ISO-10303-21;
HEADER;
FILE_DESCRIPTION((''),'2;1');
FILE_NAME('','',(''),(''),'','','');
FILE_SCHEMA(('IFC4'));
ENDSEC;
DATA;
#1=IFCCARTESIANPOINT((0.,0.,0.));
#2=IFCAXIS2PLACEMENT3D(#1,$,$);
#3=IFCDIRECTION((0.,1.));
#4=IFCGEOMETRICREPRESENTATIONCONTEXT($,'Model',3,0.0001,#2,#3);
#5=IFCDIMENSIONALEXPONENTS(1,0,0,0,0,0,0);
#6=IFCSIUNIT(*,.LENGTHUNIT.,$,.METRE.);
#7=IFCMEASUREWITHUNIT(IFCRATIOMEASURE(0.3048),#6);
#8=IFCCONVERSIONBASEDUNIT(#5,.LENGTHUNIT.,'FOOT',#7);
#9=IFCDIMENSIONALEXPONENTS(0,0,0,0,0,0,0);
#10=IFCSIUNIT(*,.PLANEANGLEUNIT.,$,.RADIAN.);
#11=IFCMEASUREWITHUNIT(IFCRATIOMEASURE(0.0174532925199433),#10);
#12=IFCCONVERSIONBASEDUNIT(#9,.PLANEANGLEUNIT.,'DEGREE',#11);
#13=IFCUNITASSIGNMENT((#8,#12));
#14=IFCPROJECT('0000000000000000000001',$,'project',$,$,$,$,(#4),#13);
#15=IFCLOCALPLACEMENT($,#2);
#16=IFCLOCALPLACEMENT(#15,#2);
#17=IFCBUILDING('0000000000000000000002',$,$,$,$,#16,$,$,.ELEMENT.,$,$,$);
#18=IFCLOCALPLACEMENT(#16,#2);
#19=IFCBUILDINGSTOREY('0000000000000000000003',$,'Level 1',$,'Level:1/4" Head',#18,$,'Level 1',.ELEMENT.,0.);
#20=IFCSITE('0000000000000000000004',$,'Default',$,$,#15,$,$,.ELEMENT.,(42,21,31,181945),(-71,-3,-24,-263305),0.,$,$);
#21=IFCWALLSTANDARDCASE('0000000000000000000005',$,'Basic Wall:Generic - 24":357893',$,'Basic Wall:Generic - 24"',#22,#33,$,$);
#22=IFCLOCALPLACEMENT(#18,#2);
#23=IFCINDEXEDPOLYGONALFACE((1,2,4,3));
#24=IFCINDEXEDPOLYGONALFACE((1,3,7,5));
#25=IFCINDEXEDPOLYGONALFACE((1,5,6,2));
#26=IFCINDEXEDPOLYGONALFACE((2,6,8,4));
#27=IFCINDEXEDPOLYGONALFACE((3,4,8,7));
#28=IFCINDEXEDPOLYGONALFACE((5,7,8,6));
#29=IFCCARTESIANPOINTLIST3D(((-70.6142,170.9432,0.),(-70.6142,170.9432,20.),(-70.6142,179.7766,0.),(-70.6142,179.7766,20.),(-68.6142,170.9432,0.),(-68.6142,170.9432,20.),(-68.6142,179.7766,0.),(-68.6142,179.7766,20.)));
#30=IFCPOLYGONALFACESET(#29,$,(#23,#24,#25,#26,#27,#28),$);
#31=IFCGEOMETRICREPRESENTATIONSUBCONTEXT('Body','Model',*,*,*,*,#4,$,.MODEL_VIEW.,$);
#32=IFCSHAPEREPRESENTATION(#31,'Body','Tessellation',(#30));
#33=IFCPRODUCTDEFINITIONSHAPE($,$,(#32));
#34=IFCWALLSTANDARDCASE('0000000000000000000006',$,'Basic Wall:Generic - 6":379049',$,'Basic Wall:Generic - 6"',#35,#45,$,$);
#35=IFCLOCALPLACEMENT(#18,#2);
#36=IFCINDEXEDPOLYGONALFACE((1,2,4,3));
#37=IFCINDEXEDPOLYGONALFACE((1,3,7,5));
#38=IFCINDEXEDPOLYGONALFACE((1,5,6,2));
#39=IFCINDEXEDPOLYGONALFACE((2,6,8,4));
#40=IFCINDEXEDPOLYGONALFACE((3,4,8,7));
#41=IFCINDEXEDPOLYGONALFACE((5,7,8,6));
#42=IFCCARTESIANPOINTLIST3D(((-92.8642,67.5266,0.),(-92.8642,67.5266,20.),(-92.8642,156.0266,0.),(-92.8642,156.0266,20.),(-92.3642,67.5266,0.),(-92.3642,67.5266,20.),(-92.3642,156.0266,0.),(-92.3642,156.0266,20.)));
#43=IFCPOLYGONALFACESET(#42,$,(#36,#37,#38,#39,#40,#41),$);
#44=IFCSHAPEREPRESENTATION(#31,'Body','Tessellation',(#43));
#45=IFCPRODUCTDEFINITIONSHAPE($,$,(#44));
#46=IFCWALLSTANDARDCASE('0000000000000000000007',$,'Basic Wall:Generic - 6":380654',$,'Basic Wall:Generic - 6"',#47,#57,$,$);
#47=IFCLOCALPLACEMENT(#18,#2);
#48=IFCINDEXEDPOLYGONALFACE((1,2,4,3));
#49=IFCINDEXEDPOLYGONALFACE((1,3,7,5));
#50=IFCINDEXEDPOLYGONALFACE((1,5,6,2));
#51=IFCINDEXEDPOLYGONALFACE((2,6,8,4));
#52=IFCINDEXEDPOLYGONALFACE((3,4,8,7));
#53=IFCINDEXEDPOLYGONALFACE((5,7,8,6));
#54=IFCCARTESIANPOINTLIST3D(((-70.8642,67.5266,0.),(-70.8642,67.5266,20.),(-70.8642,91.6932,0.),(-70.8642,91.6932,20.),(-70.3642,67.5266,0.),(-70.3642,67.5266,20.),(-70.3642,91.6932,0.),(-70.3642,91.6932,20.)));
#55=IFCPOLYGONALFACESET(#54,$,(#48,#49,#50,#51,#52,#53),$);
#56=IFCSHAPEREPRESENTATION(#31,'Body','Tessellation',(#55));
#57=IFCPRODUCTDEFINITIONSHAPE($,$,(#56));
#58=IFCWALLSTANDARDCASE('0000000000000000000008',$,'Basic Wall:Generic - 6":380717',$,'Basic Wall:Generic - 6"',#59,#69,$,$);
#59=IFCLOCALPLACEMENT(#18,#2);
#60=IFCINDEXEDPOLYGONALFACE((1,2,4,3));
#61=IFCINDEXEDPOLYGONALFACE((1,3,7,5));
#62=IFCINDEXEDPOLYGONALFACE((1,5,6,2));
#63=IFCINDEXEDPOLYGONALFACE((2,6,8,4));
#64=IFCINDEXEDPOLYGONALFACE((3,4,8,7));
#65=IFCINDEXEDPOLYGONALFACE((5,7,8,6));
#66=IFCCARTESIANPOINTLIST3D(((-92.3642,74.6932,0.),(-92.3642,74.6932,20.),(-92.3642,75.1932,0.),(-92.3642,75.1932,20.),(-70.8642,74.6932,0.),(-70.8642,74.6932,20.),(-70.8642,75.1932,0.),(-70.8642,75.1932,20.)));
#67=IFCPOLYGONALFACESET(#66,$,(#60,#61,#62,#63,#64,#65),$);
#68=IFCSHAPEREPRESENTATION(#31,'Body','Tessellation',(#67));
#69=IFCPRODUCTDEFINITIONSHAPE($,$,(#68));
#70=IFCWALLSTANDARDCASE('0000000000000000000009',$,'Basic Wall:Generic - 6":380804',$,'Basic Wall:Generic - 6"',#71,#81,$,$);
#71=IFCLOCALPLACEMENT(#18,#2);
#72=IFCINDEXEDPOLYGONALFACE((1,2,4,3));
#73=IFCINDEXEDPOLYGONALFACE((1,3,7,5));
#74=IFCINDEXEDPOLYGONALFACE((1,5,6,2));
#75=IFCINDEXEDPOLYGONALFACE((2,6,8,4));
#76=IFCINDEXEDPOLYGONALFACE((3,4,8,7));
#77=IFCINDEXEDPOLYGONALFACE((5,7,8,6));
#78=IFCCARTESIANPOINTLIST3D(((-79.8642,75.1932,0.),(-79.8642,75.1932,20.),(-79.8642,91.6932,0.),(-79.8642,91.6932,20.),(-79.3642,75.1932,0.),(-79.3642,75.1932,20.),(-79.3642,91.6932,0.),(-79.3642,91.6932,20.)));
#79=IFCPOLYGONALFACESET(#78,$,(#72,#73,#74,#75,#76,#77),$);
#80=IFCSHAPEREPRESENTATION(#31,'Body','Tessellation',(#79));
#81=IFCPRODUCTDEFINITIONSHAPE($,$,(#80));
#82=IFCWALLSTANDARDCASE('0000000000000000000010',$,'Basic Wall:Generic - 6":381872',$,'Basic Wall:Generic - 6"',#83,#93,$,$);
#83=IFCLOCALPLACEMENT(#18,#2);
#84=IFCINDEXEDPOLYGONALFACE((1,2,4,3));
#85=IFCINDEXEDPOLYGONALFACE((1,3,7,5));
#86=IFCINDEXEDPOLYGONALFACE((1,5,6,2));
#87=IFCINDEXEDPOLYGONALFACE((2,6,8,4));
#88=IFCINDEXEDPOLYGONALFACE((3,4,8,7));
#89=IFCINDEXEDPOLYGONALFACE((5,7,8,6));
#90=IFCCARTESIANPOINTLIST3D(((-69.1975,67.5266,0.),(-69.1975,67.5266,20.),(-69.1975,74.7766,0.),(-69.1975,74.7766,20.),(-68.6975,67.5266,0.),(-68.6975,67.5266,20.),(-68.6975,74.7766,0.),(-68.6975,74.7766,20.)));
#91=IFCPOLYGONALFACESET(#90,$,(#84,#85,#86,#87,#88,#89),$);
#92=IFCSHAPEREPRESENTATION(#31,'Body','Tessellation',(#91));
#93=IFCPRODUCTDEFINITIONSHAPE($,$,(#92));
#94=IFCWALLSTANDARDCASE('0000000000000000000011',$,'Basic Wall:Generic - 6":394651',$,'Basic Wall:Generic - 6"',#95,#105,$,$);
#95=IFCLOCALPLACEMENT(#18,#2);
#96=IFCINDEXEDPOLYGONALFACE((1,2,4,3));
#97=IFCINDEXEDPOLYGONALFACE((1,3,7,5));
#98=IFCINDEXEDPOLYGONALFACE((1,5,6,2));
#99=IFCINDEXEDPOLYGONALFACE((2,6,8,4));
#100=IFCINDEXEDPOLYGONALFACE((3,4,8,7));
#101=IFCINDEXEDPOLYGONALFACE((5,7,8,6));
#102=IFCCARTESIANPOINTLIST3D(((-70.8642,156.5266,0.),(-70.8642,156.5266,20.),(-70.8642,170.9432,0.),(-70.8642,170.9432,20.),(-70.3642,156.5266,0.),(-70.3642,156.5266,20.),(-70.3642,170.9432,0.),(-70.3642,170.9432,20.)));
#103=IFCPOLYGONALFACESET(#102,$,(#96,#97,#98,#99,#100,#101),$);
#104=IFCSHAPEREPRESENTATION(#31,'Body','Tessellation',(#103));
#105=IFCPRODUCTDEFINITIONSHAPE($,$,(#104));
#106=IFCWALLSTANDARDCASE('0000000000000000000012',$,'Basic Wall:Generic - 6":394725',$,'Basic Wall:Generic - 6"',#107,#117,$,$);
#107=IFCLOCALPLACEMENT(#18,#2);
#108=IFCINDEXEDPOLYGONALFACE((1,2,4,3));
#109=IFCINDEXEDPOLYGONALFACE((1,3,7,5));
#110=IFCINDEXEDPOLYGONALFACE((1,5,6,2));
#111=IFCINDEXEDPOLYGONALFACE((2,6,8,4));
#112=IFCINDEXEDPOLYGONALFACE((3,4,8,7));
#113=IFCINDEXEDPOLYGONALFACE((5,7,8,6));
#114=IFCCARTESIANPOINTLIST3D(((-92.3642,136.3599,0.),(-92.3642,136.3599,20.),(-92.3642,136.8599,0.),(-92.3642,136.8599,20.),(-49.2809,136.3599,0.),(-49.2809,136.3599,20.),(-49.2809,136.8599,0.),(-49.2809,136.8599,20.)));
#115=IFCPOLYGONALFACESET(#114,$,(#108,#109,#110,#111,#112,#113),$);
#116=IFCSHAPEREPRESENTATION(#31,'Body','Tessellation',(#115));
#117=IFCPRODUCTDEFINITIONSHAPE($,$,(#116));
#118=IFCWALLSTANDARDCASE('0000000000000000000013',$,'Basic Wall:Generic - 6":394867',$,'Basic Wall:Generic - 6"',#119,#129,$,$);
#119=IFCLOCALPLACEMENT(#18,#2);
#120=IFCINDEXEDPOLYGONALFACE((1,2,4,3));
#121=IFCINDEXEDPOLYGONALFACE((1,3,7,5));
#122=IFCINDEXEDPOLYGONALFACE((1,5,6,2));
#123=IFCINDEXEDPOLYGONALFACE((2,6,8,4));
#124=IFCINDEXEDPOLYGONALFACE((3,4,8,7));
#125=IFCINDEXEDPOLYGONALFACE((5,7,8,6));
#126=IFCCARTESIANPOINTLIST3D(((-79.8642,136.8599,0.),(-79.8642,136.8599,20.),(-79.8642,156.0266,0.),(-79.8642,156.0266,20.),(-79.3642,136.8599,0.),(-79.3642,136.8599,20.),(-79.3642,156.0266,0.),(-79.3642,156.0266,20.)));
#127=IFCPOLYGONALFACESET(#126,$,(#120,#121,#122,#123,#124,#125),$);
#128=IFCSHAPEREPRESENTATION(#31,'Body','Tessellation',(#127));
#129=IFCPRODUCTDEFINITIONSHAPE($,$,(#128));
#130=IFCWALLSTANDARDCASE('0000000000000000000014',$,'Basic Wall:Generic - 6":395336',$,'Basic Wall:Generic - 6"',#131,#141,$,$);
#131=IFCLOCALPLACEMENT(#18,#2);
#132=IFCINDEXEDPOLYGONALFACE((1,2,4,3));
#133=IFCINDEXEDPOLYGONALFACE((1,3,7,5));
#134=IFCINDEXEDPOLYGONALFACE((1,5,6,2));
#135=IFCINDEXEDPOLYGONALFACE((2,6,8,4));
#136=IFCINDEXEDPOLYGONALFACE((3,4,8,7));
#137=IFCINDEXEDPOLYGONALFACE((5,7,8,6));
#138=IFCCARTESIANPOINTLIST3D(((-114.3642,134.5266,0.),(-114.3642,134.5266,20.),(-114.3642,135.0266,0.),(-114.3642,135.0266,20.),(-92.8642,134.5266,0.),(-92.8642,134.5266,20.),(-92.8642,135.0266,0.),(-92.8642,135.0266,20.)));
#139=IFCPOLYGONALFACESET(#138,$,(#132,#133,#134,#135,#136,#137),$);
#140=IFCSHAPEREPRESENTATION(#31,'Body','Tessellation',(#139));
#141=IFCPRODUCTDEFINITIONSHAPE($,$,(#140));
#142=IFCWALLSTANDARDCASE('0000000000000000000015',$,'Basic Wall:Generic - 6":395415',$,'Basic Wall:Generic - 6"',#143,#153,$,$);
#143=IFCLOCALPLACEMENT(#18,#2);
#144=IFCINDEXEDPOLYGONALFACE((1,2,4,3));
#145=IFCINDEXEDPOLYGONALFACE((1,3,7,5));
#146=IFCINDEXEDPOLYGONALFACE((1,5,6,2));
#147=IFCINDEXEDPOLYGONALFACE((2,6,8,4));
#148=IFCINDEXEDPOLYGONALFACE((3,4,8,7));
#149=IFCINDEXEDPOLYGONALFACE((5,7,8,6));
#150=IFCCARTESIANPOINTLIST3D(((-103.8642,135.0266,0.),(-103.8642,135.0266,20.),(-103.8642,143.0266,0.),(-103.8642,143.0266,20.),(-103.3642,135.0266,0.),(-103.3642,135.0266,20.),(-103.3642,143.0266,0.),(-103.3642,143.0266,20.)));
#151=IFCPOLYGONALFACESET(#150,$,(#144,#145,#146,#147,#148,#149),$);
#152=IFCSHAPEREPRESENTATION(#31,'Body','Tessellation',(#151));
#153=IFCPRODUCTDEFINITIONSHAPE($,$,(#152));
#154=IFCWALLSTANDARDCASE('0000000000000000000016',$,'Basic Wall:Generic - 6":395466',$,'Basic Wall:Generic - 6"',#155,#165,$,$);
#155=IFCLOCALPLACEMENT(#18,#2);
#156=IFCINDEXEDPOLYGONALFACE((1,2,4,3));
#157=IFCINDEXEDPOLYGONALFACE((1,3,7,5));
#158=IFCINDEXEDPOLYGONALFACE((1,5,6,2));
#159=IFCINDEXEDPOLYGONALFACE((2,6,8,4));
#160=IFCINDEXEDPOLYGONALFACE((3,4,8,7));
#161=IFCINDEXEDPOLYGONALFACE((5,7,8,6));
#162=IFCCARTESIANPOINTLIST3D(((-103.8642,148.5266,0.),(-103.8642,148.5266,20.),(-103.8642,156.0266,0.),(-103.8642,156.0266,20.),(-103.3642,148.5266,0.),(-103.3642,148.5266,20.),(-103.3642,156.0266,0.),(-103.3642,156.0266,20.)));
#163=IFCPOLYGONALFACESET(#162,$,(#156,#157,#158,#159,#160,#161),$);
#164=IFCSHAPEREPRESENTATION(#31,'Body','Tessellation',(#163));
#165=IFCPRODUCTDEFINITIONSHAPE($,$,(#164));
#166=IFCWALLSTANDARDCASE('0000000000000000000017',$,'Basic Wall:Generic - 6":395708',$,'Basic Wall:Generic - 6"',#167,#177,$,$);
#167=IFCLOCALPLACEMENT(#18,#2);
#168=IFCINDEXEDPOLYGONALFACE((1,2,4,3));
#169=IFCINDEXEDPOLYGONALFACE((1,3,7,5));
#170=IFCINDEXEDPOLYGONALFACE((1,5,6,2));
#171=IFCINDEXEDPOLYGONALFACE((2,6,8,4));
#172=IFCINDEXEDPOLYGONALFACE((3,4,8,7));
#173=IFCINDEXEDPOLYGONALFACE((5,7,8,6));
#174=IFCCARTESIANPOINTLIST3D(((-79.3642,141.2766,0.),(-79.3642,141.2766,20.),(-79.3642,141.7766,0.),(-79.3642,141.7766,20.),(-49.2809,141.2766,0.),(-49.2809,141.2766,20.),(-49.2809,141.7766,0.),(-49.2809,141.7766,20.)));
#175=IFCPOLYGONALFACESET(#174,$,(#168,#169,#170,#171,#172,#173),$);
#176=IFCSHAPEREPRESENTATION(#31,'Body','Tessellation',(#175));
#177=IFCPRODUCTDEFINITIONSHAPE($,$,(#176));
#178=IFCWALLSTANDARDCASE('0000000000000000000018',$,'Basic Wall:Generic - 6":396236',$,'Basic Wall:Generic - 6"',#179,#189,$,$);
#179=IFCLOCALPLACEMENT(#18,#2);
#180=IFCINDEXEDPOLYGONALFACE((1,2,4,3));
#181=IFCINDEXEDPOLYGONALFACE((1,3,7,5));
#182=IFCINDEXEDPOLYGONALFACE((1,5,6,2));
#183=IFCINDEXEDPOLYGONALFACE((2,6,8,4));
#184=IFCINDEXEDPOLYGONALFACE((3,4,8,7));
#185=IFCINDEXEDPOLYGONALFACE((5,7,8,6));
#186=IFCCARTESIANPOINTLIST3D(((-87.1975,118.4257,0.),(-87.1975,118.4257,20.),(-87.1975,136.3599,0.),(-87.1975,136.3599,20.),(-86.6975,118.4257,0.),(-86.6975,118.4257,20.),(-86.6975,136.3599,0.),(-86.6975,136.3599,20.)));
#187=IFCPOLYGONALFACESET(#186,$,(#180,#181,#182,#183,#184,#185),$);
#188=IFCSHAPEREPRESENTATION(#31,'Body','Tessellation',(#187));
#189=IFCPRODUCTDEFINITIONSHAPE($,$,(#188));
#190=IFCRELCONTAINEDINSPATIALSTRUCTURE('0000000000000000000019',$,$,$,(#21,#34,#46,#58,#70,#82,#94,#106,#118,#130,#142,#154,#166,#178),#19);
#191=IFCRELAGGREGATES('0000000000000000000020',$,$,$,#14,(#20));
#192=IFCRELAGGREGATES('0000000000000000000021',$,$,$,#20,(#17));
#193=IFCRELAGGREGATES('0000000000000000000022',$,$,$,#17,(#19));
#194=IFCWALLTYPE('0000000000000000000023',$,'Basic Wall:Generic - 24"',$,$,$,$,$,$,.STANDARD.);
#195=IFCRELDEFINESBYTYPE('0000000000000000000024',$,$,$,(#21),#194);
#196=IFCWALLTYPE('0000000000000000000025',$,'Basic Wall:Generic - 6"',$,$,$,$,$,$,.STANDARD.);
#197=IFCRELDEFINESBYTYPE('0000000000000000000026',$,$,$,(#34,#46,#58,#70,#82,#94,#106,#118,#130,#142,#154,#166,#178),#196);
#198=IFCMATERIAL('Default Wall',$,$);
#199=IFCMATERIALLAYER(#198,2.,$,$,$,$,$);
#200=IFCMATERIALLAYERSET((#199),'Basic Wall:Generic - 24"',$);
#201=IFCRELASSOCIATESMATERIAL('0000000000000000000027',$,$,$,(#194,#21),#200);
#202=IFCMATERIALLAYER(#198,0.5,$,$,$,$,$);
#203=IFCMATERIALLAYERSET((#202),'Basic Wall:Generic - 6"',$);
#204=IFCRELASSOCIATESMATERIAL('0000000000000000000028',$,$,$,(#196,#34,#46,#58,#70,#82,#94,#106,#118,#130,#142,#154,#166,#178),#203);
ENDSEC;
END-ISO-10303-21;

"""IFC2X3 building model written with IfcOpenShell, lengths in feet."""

from ifc_helpers import new_model, entity, si_unit, converted_unit, direction, frame, frame_2d, origin, place, context, subcontext, project, spatial, rectangle, extrude, material, layer, layer_set, layer_usage, type_object, element, save


model = new_model("IFC2X3")

# Units and contexts
model_context = context("Model", 3, precision=0.0001, world=origin(), true_north=direction((0.0, 1.0)))
body_context = subcontext(model_context, "Body", "Model", "MODEL_VIEW")
ifc_project = project(units=[converted_unit("LENGTHUNIT", "FOOT", entity("IfcRatioMeasure", 0.3048), si_unit("LENGTHUNIT", "METRE"), dimensions=[1, 0, 0, 0, 0, 0, 0]), converted_unit("PLANEANGLEUNIT", "DEGREE", entity("IfcRatioMeasure", 0.0174532925199433), si_unit("PLANEANGLEUNIT", "RADIAN"), dimensions=[0, 0, 0, 0, 0, 0, 0])], contexts=[model_context])

# Site, building, storey
site_placement = place(None, origin())
site = spatial("IfcSite", under=ifc_project, at=site_placement, Name="Default", CompositionType="ELEMENT", RefLatitude=(42, 21, 31, 181945), RefLongitude=(-71, -3, -24, -263305), RefElevation=0.0)
building_placement = place(site_placement, origin())
building = spatial("IfcBuilding", under=site, at=building_placement, CompositionType="ELEMENT")
storey_placement = place(building_placement, origin())
storey = spatial("IfcBuildingStorey", under=building, at=storey_placement, Name="Level 1", ObjectType="Level:1/4\" Head", LongName="Level 1", CompositionType="ELEMENT", Elevation=0.0)

# Walls
ifc_material = material(Name="Default Wall")
ifc_layer_1 = layer(ifc_material, 2.0)
ifc_layer_set_1 = layer_set([ifc_layer_1], Name="Basic Wall:Generic - 24\"")
ifc_layer_usage_1 = layer_usage(ifc_layer_set_1, "AXIS2", "NEGATIVE", 1.0)
wall_type_1 = type_object("IfcWallType", Name="Basic Wall:Generic - 24\"", PredefinedType="STANDARD", material=ifc_layer_set_1)
wall_1_placement = place(storey_placement, frame((-69.6142, 179.7766, 0.0), z_axis=(0.0, 0.0, 1.0), x_axis=(0.0, -1.0, 0.0)))
element("IfcWallStandardCase", 1, at=wall_1_placement, inside=storey, type_object=wall_type_1, material=ifc_layer_usage_1, Name="Basic Wall:Generic - 24\":357893", ObjectType="Basic Wall:Generic - 24\"", context=body_context, shape_type="SweptSolid", body=[
    extrude(rectangle(XDim=8.8333, YDim=2.0, at=frame_2d((4.4167, 0.0), x_axis=(-1.0, 0.0))), origin(), (0.0, 0.0, 1.0), 20.0),
])
ifc_layer_2 = layer(ifc_material, 0.5)
ifc_layer_set_2 = layer_set([ifc_layer_2], Name="Basic Wall:Generic - 6\"")
ifc_layer_usage_2 = layer_usage(ifc_layer_set_2, "AXIS2", "NEGATIVE", 0.25)
wall_type_2 = type_object("IfcWallType", Name="Basic Wall:Generic - 6\"", PredefinedType="STANDARD", material=ifc_layer_set_2)
wall_2_placement = place(storey_placement, frame((-92.6142, 67.5266, 0.0), z_axis=(0.0, 0.0, 1.0), x_axis=(0.0, 1.0, 0.0)))
element("IfcWallStandardCase", 2, at=wall_2_placement, inside=storey, type_object=wall_type_2, material=ifc_layer_usage_2, Name="Basic Wall:Generic - 6\":379049", ObjectType="Basic Wall:Generic - 6\"", context=body_context, shape_type="SweptSolid", body=[
    extrude(rectangle(XDim=88.5, YDim=0.5, at=frame_2d((44.25, 0.0), x_axis=(-1.0, 0.0))), origin(), (0.0, 0.0, 1.0), 20.0),
])
ifc_layer_usage_3 = layer_usage(ifc_layer_set_2, "AXIS2", "NEGATIVE", 0.25)
wall_3_placement = place(storey_placement, frame((-70.6142, 67.5266, 0.0), z_axis=(0.0, 0.0, 1.0), x_axis=(0.0, 1.0, 0.0)))
element("IfcWallStandardCase", 3, at=wall_3_placement, inside=storey, type_object=wall_type_2, material=ifc_layer_usage_3, Name="Basic Wall:Generic - 6\":380654", ObjectType="Basic Wall:Generic - 6\"", context=body_context, shape_type="SweptSolid", body=[
    extrude(rectangle(XDim=24.1667, YDim=0.5, at=frame_2d((12.0833, 0.0), x_axis=(-1.0, 0.0))), origin(), (0.0, 0.0, 1.0), 20.0),
])
ifc_layer_usage_4 = layer_usage(ifc_layer_set_2, "AXIS2", "NEGATIVE", 0.25)
wall_4_placement = place(storey_placement, frame((-70.8642, 74.9432, 0.0), z_axis=(0.0, 0.0, 1.0), x_axis=(-1.0, 0.0, 0.0)))
element("IfcWallStandardCase", 4, at=wall_4_placement, inside=storey, type_object=wall_type_2, material=ifc_layer_usage_4, Name="Basic Wall:Generic - 6\":380717", ObjectType="Basic Wall:Generic - 6\"", context=body_context, shape_type="SweptSolid", body=[
    extrude(rectangle(XDim=21.5, YDim=0.5, at=frame_2d((10.75, 0.0), x_axis=(-1.0, 0.0))), origin(), (0.0, 0.0, 1.0), 20.0),
])
ifc_layer_usage_5 = layer_usage(ifc_layer_set_2, "AXIS2", "NEGATIVE", 0.25)
wall_5_placement = place(storey_placement, frame((-79.6142, 75.1932, 0.0), z_axis=(0.0, 0.0, 1.0), x_axis=(0.0, 1.0, 0.0)))
element("IfcWallStandardCase", 5, at=wall_5_placement, inside=storey, type_object=wall_type_2, material=ifc_layer_usage_5, Name="Basic Wall:Generic - 6\":380804", ObjectType="Basic Wall:Generic - 6\"", context=body_context, shape_type="SweptSolid", body=[
    extrude(rectangle(XDim=16.5, YDim=0.5, at=frame_2d((8.25, 0.0), x_axis=(-1.0, 0.0))), origin(), (0.0, 0.0, 1.0), 20.0),
])
ifc_layer_usage_6 = layer_usage(ifc_layer_set_2, "AXIS2", "NEGATIVE", 0.25)
wall_6_placement = place(storey_placement, frame((-68.9475, 74.7766, 0.0), z_axis=(0.0, 0.0, 1.0), x_axis=(0.0, -1.0, 0.0)))
element("IfcWallStandardCase", 6, at=wall_6_placement, inside=storey, type_object=wall_type_2, material=ifc_layer_usage_6, Name="Basic Wall:Generic - 6\":381872", ObjectType="Basic Wall:Generic - 6\"", context=body_context, shape_type="SweptSolid", body=[
    extrude(rectangle(XDim=7.25, YDim=0.5, at=frame_2d((3.625, 0.0), x_axis=(-1.0, 0.0))), origin(), (0.0, 0.0, 1.0), 20.0),
])
ifc_layer_usage_7 = layer_usage(ifc_layer_set_2, "AXIS2", "NEGATIVE", 0.25)
wall_7_placement = place(storey_placement, frame((-70.6142, 170.9432, 0.0), z_axis=(0.0, 0.0, 1.0), x_axis=(0.0, -1.0, 0.0)))
element("IfcWallStandardCase", 7, at=wall_7_placement, inside=storey, type_object=wall_type_2, material=ifc_layer_usage_7, Name="Basic Wall:Generic - 6\":394651", ObjectType="Basic Wall:Generic - 6\"", context=body_context, shape_type="SweptSolid", body=[
    extrude(rectangle(XDim=14.4167, YDim=0.5, at=frame_2d((7.2083, 0.0), x_axis=(-1.0, 0.0))), origin(), (0.0, 0.0, 1.0), 20.0),
])
ifc_layer_usage_8 = layer_usage(ifc_layer_set_2, "AXIS2", "NEGATIVE", 0.25)
wall_8_placement = place(storey_placement, frame((-92.3642, 136.6099, 0.0)))
element("IfcWallStandardCase", 8, at=wall_8_placement, inside=storey, type_object=wall_type_2, material=ifc_layer_usage_8, Name="Basic Wall:Generic - 6\":394725", ObjectType="Basic Wall:Generic - 6\"", context=body_context, shape_type="SweptSolid", body=[
    extrude(rectangle(XDim=43.0833, YDim=0.5, at=frame_2d((21.5417, 0.0), x_axis=(-1.0, 0.0))), origin(), (0.0, 0.0, 1.0), 20.0),
])
ifc_layer_usage_9 = layer_usage(ifc_layer_set_2, "AXIS2", "NEGATIVE", 0.25)
wall_9_placement = place(storey_placement, frame((-79.6142, 156.0266, 0.0), z_axis=(0.0, 0.0, 1.0), x_axis=(0.0, -1.0, 0.0)))
element("IfcWallStandardCase", 9, at=wall_9_placement, inside=storey, type_object=wall_type_2, material=ifc_layer_usage_9, Name="Basic Wall:Generic - 6\":394867", ObjectType="Basic Wall:Generic - 6\"", context=body_context, shape_type="SweptSolid", body=[
    extrude(rectangle(XDim=19.1667, YDim=0.5, at=frame_2d((9.5833, 0.0), x_axis=(-1.0, 0.0))), origin(), (0.0, 0.0, 1.0), 20.0),
])
ifc_layer_usage_10 = layer_usage(ifc_layer_set_2, "AXIS2", "POSITIVE", -0.25)
wall_10_placement = place(storey_placement, frame((-92.8642, 134.7766, 0.0), z_axis=(0.0, 0.0, 1.0), x_axis=(-1.0, 0.0, 0.0)))
element("IfcWallStandardCase", 10, at=wall_10_placement, inside=storey, type_object=wall_type_2, material=ifc_layer_usage_10, Name="Basic Wall:Generic - 6\":395336", ObjectType="Basic Wall:Generic - 6\"", context=body_context, shape_type="SweptSolid", body=[
    extrude(rectangle(XDim=21.5, YDim=0.5, at=frame_2d((10.75, 0.0), x_axis=(-1.0, 0.0))), origin(), (0.0, 0.0, 1.0), 20.0),
])
ifc_layer_usage_11 = layer_usage(ifc_layer_set_2, "AXIS2", "NEGATIVE", 0.25)
wall_11_placement = place(storey_placement, frame((-103.6142, 143.0266, 0.0), z_axis=(0.0, 0.0, 1.0), x_axis=(0.0, -1.0, 0.0)))
element("IfcWallStandardCase", 11, at=wall_11_placement, inside=storey, type_object=wall_type_2, material=ifc_layer_usage_11, Name="Basic Wall:Generic - 6\":395415", ObjectType="Basic Wall:Generic - 6\"", context=body_context, shape_type="SweptSolid", body=[
    extrude(rectangle(XDim=8.0, YDim=0.5, at=frame_2d((4.0, 0.0), x_axis=(-1.0, 0.0))), origin(), (0.0, 0.0, 1.0), 20.0),
])
ifc_layer_usage_12 = layer_usage(ifc_layer_set_2, "AXIS2", "NEGATIVE", 0.25)
wall_12_placement = place(storey_placement, frame((-103.6142, 156.0266, 0.0), z_axis=(0.0, 0.0, 1.0), x_axis=(0.0, -1.0, 0.0)))
element("IfcWallStandardCase", 12, at=wall_12_placement, inside=storey, type_object=wall_type_2, material=ifc_layer_usage_12, Name="Basic Wall:Generic - 6\":395466", ObjectType="Basic Wall:Generic - 6\"", context=body_context, shape_type="SweptSolid", body=[
    extrude(rectangle(XDim=7.5, YDim=0.5, at=frame_2d((3.75, 0.0), x_axis=(-1.0, 0.0))), origin(), (0.0, 0.0, 1.0), 20.0),
])
ifc_layer_usage_13 = layer_usage(ifc_layer_set_2, "AXIS2", "NEGATIVE", 0.25)
wall_13_placement = place(storey_placement, frame((-79.3642, 141.5266, 0.0)))
element("IfcWallStandardCase", 13, at=wall_13_placement, inside=storey, type_object=wall_type_2, material=ifc_layer_usage_13, Name="Basic Wall:Generic - 6\":395708", ObjectType="Basic Wall:Generic - 6\"", context=body_context, shape_type="SweptSolid", body=[
    extrude(rectangle(XDim=30.0833, YDim=0.5, at=frame_2d((15.0417, 0.0), x_axis=(-1.0, 0.0))), origin(), (0.0, 0.0, 1.0), 20.0),
])
ifc_layer_usage_14 = layer_usage(ifc_layer_set_2, "AXIS2", "NEGATIVE", 0.25)
wall_14_placement = place(storey_placement, frame((-86.9475, 136.3599, 0.0), z_axis=(0.0, 0.0, 1.0), x_axis=(0.0, -1.0, 0.0)))
element("IfcWallStandardCase", 14, at=wall_14_placement, inside=storey, type_object=wall_type_2, material=ifc_layer_usage_14, Name="Basic Wall:Generic - 6\":396236", ObjectType="Basic Wall:Generic - 6\"", context=body_context, shape_type="SweptSolid", body=[
    extrude(rectangle(XDim=17.9342, YDim=0.5, at=frame_2d((8.9671, 0.0), x_axis=(-1.0, 0.0))), origin(), (0.0, 0.0, 1.0), 20.0),
])

save(model, "model.ifc")
